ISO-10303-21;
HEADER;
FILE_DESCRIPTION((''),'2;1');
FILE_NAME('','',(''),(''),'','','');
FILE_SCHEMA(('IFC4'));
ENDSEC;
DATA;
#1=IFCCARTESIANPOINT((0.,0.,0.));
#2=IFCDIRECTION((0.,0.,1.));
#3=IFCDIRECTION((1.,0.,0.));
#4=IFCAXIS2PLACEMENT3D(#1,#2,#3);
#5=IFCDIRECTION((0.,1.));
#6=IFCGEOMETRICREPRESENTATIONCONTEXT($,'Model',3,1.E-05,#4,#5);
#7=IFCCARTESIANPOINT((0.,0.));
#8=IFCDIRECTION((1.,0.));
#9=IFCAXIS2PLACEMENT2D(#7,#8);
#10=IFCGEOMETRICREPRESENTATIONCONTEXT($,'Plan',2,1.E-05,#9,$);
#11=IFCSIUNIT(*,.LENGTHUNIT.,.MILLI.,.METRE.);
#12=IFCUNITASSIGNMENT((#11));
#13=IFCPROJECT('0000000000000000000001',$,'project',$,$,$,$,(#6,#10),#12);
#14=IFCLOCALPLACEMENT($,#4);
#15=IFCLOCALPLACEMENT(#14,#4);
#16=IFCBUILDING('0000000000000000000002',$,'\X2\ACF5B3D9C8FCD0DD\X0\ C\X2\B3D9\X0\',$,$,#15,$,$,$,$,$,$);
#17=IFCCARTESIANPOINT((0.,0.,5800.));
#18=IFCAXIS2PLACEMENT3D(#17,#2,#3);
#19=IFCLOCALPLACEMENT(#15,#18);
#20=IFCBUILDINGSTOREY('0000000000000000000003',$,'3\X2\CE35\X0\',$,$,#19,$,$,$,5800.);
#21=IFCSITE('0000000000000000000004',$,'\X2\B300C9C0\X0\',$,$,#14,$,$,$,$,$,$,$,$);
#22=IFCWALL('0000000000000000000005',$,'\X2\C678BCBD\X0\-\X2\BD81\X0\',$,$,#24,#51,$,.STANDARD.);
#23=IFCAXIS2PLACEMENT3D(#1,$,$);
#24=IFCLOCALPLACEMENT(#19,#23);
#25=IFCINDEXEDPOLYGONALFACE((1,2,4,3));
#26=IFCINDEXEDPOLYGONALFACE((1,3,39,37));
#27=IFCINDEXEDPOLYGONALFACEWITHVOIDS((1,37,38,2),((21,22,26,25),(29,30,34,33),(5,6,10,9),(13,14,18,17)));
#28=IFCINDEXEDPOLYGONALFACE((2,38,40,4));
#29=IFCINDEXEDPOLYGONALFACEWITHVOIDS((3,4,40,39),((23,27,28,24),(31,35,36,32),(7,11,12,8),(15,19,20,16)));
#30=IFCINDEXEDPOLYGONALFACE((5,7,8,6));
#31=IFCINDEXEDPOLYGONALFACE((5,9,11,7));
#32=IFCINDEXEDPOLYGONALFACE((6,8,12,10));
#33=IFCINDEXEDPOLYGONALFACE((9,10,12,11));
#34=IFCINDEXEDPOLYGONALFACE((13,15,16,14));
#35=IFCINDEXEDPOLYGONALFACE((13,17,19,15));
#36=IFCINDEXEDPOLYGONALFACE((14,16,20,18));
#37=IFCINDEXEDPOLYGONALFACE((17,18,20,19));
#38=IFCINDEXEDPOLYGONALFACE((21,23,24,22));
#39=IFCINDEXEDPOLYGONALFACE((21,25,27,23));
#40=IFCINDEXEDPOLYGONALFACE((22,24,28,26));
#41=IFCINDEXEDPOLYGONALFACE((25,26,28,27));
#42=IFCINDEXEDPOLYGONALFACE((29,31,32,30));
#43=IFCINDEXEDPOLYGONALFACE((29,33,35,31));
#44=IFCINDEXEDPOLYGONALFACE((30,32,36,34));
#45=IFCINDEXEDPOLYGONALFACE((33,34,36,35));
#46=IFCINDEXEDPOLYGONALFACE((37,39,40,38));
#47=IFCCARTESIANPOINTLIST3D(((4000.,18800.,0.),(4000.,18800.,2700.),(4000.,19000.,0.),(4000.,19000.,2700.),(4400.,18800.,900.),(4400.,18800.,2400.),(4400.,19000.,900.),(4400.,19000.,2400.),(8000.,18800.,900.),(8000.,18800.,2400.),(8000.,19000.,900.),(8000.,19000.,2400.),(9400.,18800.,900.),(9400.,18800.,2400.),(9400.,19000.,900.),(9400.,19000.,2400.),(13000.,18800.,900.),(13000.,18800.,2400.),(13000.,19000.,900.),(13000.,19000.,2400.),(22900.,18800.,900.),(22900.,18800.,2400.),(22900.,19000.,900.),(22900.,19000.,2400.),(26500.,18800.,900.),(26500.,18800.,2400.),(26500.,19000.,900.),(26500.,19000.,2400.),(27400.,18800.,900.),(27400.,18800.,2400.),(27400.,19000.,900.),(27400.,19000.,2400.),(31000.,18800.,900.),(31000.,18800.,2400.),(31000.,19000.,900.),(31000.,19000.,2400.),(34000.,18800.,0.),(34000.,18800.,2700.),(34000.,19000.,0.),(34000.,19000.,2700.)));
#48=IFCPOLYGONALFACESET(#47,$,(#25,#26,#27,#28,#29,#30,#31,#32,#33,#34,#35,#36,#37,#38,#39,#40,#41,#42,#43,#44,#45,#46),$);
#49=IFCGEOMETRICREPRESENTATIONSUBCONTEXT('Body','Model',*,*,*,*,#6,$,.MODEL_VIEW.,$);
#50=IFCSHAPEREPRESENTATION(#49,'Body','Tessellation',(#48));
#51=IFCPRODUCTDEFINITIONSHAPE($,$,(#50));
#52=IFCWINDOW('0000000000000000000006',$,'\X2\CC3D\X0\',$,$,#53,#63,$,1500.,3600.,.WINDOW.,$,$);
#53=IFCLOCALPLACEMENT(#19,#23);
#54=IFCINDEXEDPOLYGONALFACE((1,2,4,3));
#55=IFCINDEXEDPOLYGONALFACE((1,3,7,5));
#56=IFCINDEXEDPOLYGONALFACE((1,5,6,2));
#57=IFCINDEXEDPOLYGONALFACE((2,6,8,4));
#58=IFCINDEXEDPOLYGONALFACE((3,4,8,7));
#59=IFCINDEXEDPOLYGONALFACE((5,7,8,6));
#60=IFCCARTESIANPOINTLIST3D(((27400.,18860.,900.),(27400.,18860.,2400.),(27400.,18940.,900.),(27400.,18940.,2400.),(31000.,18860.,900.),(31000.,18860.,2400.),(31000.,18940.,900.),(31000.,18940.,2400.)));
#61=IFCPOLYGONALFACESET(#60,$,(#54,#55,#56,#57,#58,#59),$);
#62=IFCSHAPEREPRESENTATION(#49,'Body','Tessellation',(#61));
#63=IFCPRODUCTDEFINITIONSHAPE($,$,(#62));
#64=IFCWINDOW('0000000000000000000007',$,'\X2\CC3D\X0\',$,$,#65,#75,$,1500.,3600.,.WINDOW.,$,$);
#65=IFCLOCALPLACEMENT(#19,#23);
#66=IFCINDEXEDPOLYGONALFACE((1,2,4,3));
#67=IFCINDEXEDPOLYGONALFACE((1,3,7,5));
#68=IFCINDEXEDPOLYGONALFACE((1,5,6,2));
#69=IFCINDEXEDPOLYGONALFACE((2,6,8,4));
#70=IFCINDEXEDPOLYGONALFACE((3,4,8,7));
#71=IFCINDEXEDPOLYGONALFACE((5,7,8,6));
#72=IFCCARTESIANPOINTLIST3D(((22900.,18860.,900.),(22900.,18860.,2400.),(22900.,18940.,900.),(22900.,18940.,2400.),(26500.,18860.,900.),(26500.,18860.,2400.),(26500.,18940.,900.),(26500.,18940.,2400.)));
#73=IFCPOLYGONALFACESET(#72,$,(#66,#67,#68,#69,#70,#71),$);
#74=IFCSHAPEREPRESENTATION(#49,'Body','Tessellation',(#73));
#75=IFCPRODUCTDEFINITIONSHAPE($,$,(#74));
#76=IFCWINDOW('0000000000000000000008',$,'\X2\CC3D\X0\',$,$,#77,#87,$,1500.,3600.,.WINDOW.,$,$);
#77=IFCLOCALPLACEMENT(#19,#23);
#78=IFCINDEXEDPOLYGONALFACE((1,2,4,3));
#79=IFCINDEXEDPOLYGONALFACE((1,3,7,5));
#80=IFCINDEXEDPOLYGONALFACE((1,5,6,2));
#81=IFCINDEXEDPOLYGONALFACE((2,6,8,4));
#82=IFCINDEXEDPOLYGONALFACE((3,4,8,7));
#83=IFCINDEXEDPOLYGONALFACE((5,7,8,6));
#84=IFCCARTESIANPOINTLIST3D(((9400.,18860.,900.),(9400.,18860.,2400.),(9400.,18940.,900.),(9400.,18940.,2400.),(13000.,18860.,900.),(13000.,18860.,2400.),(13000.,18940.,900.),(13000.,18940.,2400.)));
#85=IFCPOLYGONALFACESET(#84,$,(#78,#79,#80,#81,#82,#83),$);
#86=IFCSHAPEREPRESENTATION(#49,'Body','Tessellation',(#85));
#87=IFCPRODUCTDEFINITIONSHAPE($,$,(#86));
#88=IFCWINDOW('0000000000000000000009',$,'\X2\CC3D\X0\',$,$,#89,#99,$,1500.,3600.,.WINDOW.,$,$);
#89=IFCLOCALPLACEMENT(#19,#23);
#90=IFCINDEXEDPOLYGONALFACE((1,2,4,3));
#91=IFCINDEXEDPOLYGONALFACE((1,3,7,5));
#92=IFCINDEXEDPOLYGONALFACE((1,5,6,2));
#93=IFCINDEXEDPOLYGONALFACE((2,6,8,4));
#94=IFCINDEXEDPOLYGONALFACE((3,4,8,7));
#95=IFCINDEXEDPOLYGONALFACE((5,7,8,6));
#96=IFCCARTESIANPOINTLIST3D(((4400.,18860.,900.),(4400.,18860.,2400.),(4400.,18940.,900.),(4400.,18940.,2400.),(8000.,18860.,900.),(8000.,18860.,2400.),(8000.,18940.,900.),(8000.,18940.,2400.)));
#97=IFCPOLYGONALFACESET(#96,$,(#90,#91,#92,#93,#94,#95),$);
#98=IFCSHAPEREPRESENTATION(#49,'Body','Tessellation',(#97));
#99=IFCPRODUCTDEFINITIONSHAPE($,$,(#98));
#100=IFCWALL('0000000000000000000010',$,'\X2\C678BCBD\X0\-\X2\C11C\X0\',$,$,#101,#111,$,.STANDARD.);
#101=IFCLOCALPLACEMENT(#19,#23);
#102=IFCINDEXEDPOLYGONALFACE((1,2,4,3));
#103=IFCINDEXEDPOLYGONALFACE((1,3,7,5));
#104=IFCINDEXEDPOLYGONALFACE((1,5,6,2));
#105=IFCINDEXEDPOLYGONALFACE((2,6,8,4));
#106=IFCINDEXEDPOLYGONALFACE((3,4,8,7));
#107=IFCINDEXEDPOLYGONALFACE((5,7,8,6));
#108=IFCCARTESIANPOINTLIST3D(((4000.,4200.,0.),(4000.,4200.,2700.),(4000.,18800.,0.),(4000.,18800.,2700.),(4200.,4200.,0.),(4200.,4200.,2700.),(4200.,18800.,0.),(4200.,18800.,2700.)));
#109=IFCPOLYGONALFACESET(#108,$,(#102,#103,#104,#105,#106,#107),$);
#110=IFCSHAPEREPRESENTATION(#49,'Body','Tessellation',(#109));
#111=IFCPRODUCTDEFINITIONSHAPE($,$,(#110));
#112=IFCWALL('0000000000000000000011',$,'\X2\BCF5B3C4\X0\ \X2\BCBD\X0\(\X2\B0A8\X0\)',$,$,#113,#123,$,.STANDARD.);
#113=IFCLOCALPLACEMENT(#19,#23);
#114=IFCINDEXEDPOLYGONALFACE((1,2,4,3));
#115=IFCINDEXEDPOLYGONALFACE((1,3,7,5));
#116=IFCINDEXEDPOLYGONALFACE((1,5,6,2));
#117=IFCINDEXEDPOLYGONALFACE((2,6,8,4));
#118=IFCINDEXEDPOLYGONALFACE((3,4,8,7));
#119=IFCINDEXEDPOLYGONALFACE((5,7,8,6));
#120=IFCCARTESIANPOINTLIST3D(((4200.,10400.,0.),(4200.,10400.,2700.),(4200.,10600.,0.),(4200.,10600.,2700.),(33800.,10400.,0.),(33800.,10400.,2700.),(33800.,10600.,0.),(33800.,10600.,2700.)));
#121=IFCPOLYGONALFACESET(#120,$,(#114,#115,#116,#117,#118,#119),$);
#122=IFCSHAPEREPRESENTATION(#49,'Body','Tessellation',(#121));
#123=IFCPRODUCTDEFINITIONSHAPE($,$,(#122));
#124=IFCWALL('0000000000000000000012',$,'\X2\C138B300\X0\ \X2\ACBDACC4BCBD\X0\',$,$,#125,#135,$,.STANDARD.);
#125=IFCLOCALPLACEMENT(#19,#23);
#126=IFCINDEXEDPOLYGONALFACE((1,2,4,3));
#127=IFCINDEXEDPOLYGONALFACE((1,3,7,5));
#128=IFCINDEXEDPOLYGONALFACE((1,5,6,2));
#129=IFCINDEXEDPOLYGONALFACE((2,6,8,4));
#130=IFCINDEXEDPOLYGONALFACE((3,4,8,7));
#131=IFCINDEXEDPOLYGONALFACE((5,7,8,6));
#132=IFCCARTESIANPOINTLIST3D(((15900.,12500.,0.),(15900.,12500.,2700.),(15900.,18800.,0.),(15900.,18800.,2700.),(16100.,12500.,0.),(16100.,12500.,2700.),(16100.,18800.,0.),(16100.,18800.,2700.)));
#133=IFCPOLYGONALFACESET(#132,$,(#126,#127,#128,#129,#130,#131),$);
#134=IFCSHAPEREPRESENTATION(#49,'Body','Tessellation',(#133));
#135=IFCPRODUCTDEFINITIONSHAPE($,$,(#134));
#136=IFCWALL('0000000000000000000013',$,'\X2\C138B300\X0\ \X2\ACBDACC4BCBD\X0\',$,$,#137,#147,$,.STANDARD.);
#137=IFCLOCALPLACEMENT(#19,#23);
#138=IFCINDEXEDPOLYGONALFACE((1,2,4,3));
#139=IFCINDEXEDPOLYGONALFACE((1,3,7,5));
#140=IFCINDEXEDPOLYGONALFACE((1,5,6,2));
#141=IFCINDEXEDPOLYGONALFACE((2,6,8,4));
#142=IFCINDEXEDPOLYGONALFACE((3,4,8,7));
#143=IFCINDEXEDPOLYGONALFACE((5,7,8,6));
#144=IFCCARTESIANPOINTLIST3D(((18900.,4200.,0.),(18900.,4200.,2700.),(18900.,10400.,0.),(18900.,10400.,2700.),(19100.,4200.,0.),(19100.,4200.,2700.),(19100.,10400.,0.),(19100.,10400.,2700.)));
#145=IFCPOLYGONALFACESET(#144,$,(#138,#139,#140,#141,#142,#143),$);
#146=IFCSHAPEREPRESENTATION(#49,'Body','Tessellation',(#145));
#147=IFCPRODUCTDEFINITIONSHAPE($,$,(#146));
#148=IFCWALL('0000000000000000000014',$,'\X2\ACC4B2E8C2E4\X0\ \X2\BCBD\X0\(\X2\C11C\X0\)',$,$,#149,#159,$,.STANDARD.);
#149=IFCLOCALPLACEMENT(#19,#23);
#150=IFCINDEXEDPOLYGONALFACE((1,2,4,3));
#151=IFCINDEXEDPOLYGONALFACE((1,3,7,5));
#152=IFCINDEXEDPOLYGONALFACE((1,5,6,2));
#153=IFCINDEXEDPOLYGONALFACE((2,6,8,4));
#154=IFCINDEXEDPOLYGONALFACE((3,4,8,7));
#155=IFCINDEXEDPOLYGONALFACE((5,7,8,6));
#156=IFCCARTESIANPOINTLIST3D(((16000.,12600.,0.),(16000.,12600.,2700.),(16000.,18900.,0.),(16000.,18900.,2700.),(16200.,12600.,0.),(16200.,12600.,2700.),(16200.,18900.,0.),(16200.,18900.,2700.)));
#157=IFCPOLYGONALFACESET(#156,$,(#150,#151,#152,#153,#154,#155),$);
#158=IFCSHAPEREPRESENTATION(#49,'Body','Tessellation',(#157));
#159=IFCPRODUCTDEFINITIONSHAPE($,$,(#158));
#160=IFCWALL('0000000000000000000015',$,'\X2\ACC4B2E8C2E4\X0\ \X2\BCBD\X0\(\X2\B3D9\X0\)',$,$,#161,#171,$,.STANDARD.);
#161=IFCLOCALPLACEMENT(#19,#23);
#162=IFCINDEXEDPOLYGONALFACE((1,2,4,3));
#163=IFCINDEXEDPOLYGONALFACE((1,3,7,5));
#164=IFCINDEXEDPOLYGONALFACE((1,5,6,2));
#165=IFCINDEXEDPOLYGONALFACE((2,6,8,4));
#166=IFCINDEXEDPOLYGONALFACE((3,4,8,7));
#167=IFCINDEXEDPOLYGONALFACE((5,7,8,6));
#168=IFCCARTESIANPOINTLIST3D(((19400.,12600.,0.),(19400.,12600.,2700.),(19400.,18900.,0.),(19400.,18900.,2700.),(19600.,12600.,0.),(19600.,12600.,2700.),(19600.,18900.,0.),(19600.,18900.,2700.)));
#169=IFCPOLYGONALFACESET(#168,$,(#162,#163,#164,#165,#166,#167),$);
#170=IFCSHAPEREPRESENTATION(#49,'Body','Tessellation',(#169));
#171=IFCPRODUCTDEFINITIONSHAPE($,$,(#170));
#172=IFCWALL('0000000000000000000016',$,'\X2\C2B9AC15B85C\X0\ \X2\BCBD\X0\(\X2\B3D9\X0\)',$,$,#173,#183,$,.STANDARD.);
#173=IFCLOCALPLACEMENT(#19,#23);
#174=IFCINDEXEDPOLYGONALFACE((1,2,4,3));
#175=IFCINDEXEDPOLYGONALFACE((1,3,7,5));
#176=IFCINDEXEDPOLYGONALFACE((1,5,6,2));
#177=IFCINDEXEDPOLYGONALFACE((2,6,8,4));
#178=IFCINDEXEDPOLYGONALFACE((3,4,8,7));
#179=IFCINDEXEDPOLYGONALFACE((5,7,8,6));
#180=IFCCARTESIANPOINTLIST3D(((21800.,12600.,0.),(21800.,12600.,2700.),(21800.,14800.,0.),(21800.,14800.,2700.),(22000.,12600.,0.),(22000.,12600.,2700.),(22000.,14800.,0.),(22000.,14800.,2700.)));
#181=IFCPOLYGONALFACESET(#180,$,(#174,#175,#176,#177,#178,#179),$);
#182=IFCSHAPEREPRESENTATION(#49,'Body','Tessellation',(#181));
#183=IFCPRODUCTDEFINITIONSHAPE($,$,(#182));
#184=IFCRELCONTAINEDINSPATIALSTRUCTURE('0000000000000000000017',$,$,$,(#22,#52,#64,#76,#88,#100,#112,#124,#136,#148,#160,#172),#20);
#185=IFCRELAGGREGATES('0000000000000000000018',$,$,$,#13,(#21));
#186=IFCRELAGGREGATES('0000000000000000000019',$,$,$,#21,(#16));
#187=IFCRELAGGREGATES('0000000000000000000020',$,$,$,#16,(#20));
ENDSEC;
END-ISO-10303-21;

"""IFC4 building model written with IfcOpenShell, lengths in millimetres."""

from ifc_helpers import new_model, si_unit, direction, frame, origin_with_axes, origin_2d_with_axis, place, context, subcontext, project, spatial, polyline, outline, extrude, element, fill, save


model = new_model("IFC4")

# Units and contexts
model_context = context("Model", 3, precision=1e-05, world=origin_with_axes(), true_north=direction((0.0, 1.0)))
plan_context = context("Plan", 2, precision=1e-05, world=origin_2d_with_axis())
body_context = subcontext(model_context, "Body", "Model", "MODEL_VIEW")
ifc_project = project(units=[si_unit("LENGTHUNIT", "METRE", prefix="MILLI")], contexts=[model_context, plan_context])

# Site, building, storey
site_placement = place(None, origin_with_axes())
site = spatial("IfcSite", under=ifc_project, at=site_placement, Name="대지")
building_placement = place(site_placement, origin_with_axes())
building = spatial("IfcBuilding", under=site, at=building_placement, Name="공동주택 C동")
storey_placement = place(building_placement, frame((0.0, 0.0, 5800.0), z_axis=(0.0, 0.0, 1.0), x_axis=(1.0, 0.0, 0.0)))
storey = spatial("IfcBuildingStorey", under=building, at=storey_placement, Name="3층", Elevation=5800.0)

# Wall, openings, windows
wall_1_placement = place(storey_placement, origin_with_axes())
wall_1 = element("IfcWall", 1, at=wall_1_placement, inside=storey, Name="외벽-북", PredefinedType="STANDARD", context=body_context, shape_type="SweptSolid", body=[
    extrude(outline(polyline([(34000.0, 18800.0), (4000.0, 18800.0), (4000.0, 19000.0), (34000.0, 19000.0), (34000.0, 18800.0)])), origin_with_axes(), (0.0, 0.0, 1.0), 2700.0),
])
opening_1_placement = place(storey_placement, origin_with_axes())
opening_1 = element("IfcOpeningElement", 2, at=opening_1_placement, cuts=wall_1, PredefinedType="OPENING", context=body_context, shape_type="SweptSolid", body=[
    extrude(outline(polyline([(31000.0, 19050.0), (27400.0, 19050.0), (27400.0, 18750.0), (31000.0, 18750.0), (31000.0, 19050.0)])), frame((0.0, 0.0, 900.0), z_axis=(0.0, 0.0, 1.0), x_axis=(1.0, 0.0, 0.0)), (0.0, 0.0, 1.0), 1500.0),
])
opening_2_placement = place(storey_placement, origin_with_axes())
opening_2 = element("IfcOpeningElement", 3, at=opening_2_placement, cuts=wall_1, PredefinedType="OPENING", context=body_context, shape_type="SweptSolid", body=[
    extrude(outline(polyline([(26500.0, 19050.0), (22900.0, 19050.0), (22900.0, 18750.0), (26500.0, 18750.0), (26500.0, 19050.0)])), frame((0.0, 0.0, 900.0), z_axis=(0.0, 0.0, 1.0), x_axis=(1.0, 0.0, 0.0)), (0.0, 0.0, 1.0), 1500.0),
])
opening_3_placement = place(storey_placement, origin_with_axes())
opening_3 = element("IfcOpeningElement", 4, at=opening_3_placement, cuts=wall_1, PredefinedType="OPENING", context=body_context, shape_type="SweptSolid", body=[
    extrude(outline(polyline([(13000.0, 19050.0), (9400.0, 19050.0), (9400.0, 18750.0), (13000.0, 18750.0), (13000.0, 19050.0)])), frame((0.0, 0.0, 900.0), z_axis=(0.0, 0.0, 1.0), x_axis=(1.0, 0.0, 0.0)), (0.0, 0.0, 1.0), 1500.0),
])
opening_4_placement = place(storey_placement, origin_with_axes())
opening_4 = element("IfcOpeningElement", 5, at=opening_4_placement, cuts=wall_1, PredefinedType="OPENING", context=body_context, shape_type="SweptSolid", body=[
    extrude(outline(polyline([(8000.0, 19050.0), (4400.0, 19050.0), (4400.0, 18750.0), (8000.0, 18750.0), (8000.0, 19050.0)])), frame((0.0, 0.0, 900.0), z_axis=(0.0, 0.0, 1.0), x_axis=(1.0, 0.0, 0.0)), (0.0, 0.0, 1.0), 1500.0),
])
window_1_placement = place(storey_placement, origin_with_axes())
window_1 = element("IfcWindow", 6, at=window_1_placement, inside=storey, Name="창", OverallHeight=1500.0, OverallWidth=3600.0, PredefinedType="WINDOW", context=body_context, shape_type="SweptSolid", body=[
    extrude(outline(polyline([(31000.0, 18940.0), (27400.0, 18940.0), (27400.0, 18860.0), (31000.0, 18860.0), (31000.0, 18940.0)])), frame((0.0, 0.0, 900.0), z_axis=(0.0, 0.0, 1.0), x_axis=(1.0, 0.0, 0.0)), (0.0, 0.0, 1.0), 1500.0),
])
fill(opening_1, window_1)
window_2_placement = place(storey_placement, origin_with_axes())
window_2 = element("IfcWindow", 7, at=window_2_placement, inside=storey, Name="창", OverallHeight=1500.0, OverallWidth=3600.0, PredefinedType="WINDOW", context=body_context, shape_type="SweptSolid", body=[
    extrude(outline(polyline([(26500.0, 18940.0), (22900.0, 18940.0), (22900.0, 18860.0), (26500.0, 18860.0), (26500.0, 18940.0)])), frame((0.0, 0.0, 900.0), z_axis=(0.0, 0.0, 1.0), x_axis=(1.0, 0.0, 0.0)), (0.0, 0.0, 1.0), 1500.0),
])
fill(opening_2, window_2)
window_3_placement = place(storey_placement, origin_with_axes())
window_3 = element("IfcWindow", 8, at=window_3_placement, inside=storey, Name="창", OverallHeight=1500.0, OverallWidth=3600.0, PredefinedType="WINDOW", context=body_context, shape_type="SweptSolid", body=[
    extrude(outline(polyline([(13000.0, 18940.0), (9400.0, 18940.0), (9400.0, 18860.0), (13000.0, 18860.0), (13000.0, 18940.0)])), frame((0.0, 0.0, 900.0), z_axis=(0.0, 0.0, 1.0), x_axis=(1.0, 0.0, 0.0)), (0.0, 0.0, 1.0), 1500.0),
])
fill(opening_3, window_3)
window_4_placement = place(storey_placement, origin_with_axes())
window_4 = element("IfcWindow", 9, at=window_4_placement, inside=storey, Name="창", OverallHeight=1500.0, OverallWidth=3600.0, PredefinedType="WINDOW", context=body_context, shape_type="SweptSolid", body=[
    extrude(outline(polyline([(8000.0, 18940.0), (4400.0, 18940.0), (4400.0, 18860.0), (8000.0, 18860.0), (8000.0, 18940.0)])), frame((0.0, 0.0, 900.0), z_axis=(0.0, 0.0, 1.0), x_axis=(1.0, 0.0, 0.0)), (0.0, 0.0, 1.0), 1500.0),
])
fill(opening_4, window_4)

# Walls
wall_2_placement = place(storey_placement, origin_with_axes())
element("IfcWall", 10, at=wall_2_placement, inside=storey, Name="외벽-서", PredefinedType="STANDARD", context=body_context, shape_type="SweptSolid", body=[
    extrude(outline(polyline([(4200.0, 18800.0), (4200.0, 4200.0), (4000.0, 4200.0), (4000.0, 18800.0), (4200.0, 18800.0)])), origin_with_axes(), (0.0, 0.0, 1.0), 2700.0),
])
wall_3_placement = place(storey_placement, origin_with_axes())
element("IfcWall", 11, at=wall_3_placement, inside=storey, Name="복도 벽(남)", PredefinedType="STANDARD", context=body_context, shape_type="SweptSolid", body=[
    extrude(outline(polyline([(4200.0, 10600.0), (33800.0, 10600.0), (33800.0, 10400.0), (4200.0, 10400.0), (4200.0, 10600.0)])), origin_with_axes(), (0.0, 0.0, 1.0), 2700.0),
])
wall_4_placement = place(storey_placement, origin_with_axes())
element("IfcWall", 12, at=wall_4_placement, inside=storey, Name="세대 경계벽", PredefinedType="STANDARD", context=body_context, shape_type="SweptSolid", body=[
    extrude(outline(polyline([(15900.0, 12500.0), (15900.0, 18800.0), (16100.0, 18800.0), (16100.0, 12500.0), (15900.0, 12500.0)])), origin_with_axes(), (0.0, 0.0, 1.0), 2700.0),
])
wall_5_placement = place(storey_placement, origin_with_axes())
element("IfcWall", 13, at=wall_5_placement, inside=storey, Name="세대 경계벽", PredefinedType="STANDARD", context=body_context, shape_type="SweptSolid", body=[
    extrude(outline(polyline([(18900.0, 4200.0), (18900.0, 10400.0), (19100.0, 10400.0), (19100.0, 4200.0), (18900.0, 4200.0)])), origin_with_axes(), (0.0, 0.0, 1.0), 2700.0),
])
wall_6_placement = place(storey_placement, origin_with_axes())
element("IfcWall", 14, at=wall_6_placement, inside=storey, Name="계단실 벽(서)", PredefinedType="STANDARD", context=body_context, shape_type="SweptSolid", body=[
    extrude(outline(polyline([(16000.0, 12600.0), (16000.0, 18900.0), (16200.0, 18900.0), (16200.0, 12600.0), (16000.0, 12600.0)])), origin_with_axes(), (0.0, 0.0, 1.0), 2700.0),
])
wall_7_placement = place(storey_placement, origin_with_axes())
element("IfcWall", 15, at=wall_7_placement, inside=storey, Name="계단실 벽(동)", PredefinedType="STANDARD", context=body_context, shape_type="SweptSolid", body=[
    extrude(outline(polyline([(19400.0, 12600.0), (19400.0, 18900.0), (19600.0, 18900.0), (19600.0, 12600.0), (19400.0, 12600.0)])), origin_with_axes(), (0.0, 0.0, 1.0), 2700.0),
])
wall_8_placement = place(storey_placement, origin_with_axes())
element("IfcWall", 16, at=wall_8_placement, inside=storey, Name="승강로 벽(동)", PredefinedType="STANDARD", context=body_context, shape_type="SweptSolid", body=[
    extrude(outline(polyline([(21800.0, 12600.0), (21800.0, 14800.0), (22000.0, 14800.0), (22000.0, 12600.0), (21800.0, 12600.0)])), origin_with_axes(), (0.0, 0.0, 1.0), 2700.0),
])

save(model, "model.ifc")
